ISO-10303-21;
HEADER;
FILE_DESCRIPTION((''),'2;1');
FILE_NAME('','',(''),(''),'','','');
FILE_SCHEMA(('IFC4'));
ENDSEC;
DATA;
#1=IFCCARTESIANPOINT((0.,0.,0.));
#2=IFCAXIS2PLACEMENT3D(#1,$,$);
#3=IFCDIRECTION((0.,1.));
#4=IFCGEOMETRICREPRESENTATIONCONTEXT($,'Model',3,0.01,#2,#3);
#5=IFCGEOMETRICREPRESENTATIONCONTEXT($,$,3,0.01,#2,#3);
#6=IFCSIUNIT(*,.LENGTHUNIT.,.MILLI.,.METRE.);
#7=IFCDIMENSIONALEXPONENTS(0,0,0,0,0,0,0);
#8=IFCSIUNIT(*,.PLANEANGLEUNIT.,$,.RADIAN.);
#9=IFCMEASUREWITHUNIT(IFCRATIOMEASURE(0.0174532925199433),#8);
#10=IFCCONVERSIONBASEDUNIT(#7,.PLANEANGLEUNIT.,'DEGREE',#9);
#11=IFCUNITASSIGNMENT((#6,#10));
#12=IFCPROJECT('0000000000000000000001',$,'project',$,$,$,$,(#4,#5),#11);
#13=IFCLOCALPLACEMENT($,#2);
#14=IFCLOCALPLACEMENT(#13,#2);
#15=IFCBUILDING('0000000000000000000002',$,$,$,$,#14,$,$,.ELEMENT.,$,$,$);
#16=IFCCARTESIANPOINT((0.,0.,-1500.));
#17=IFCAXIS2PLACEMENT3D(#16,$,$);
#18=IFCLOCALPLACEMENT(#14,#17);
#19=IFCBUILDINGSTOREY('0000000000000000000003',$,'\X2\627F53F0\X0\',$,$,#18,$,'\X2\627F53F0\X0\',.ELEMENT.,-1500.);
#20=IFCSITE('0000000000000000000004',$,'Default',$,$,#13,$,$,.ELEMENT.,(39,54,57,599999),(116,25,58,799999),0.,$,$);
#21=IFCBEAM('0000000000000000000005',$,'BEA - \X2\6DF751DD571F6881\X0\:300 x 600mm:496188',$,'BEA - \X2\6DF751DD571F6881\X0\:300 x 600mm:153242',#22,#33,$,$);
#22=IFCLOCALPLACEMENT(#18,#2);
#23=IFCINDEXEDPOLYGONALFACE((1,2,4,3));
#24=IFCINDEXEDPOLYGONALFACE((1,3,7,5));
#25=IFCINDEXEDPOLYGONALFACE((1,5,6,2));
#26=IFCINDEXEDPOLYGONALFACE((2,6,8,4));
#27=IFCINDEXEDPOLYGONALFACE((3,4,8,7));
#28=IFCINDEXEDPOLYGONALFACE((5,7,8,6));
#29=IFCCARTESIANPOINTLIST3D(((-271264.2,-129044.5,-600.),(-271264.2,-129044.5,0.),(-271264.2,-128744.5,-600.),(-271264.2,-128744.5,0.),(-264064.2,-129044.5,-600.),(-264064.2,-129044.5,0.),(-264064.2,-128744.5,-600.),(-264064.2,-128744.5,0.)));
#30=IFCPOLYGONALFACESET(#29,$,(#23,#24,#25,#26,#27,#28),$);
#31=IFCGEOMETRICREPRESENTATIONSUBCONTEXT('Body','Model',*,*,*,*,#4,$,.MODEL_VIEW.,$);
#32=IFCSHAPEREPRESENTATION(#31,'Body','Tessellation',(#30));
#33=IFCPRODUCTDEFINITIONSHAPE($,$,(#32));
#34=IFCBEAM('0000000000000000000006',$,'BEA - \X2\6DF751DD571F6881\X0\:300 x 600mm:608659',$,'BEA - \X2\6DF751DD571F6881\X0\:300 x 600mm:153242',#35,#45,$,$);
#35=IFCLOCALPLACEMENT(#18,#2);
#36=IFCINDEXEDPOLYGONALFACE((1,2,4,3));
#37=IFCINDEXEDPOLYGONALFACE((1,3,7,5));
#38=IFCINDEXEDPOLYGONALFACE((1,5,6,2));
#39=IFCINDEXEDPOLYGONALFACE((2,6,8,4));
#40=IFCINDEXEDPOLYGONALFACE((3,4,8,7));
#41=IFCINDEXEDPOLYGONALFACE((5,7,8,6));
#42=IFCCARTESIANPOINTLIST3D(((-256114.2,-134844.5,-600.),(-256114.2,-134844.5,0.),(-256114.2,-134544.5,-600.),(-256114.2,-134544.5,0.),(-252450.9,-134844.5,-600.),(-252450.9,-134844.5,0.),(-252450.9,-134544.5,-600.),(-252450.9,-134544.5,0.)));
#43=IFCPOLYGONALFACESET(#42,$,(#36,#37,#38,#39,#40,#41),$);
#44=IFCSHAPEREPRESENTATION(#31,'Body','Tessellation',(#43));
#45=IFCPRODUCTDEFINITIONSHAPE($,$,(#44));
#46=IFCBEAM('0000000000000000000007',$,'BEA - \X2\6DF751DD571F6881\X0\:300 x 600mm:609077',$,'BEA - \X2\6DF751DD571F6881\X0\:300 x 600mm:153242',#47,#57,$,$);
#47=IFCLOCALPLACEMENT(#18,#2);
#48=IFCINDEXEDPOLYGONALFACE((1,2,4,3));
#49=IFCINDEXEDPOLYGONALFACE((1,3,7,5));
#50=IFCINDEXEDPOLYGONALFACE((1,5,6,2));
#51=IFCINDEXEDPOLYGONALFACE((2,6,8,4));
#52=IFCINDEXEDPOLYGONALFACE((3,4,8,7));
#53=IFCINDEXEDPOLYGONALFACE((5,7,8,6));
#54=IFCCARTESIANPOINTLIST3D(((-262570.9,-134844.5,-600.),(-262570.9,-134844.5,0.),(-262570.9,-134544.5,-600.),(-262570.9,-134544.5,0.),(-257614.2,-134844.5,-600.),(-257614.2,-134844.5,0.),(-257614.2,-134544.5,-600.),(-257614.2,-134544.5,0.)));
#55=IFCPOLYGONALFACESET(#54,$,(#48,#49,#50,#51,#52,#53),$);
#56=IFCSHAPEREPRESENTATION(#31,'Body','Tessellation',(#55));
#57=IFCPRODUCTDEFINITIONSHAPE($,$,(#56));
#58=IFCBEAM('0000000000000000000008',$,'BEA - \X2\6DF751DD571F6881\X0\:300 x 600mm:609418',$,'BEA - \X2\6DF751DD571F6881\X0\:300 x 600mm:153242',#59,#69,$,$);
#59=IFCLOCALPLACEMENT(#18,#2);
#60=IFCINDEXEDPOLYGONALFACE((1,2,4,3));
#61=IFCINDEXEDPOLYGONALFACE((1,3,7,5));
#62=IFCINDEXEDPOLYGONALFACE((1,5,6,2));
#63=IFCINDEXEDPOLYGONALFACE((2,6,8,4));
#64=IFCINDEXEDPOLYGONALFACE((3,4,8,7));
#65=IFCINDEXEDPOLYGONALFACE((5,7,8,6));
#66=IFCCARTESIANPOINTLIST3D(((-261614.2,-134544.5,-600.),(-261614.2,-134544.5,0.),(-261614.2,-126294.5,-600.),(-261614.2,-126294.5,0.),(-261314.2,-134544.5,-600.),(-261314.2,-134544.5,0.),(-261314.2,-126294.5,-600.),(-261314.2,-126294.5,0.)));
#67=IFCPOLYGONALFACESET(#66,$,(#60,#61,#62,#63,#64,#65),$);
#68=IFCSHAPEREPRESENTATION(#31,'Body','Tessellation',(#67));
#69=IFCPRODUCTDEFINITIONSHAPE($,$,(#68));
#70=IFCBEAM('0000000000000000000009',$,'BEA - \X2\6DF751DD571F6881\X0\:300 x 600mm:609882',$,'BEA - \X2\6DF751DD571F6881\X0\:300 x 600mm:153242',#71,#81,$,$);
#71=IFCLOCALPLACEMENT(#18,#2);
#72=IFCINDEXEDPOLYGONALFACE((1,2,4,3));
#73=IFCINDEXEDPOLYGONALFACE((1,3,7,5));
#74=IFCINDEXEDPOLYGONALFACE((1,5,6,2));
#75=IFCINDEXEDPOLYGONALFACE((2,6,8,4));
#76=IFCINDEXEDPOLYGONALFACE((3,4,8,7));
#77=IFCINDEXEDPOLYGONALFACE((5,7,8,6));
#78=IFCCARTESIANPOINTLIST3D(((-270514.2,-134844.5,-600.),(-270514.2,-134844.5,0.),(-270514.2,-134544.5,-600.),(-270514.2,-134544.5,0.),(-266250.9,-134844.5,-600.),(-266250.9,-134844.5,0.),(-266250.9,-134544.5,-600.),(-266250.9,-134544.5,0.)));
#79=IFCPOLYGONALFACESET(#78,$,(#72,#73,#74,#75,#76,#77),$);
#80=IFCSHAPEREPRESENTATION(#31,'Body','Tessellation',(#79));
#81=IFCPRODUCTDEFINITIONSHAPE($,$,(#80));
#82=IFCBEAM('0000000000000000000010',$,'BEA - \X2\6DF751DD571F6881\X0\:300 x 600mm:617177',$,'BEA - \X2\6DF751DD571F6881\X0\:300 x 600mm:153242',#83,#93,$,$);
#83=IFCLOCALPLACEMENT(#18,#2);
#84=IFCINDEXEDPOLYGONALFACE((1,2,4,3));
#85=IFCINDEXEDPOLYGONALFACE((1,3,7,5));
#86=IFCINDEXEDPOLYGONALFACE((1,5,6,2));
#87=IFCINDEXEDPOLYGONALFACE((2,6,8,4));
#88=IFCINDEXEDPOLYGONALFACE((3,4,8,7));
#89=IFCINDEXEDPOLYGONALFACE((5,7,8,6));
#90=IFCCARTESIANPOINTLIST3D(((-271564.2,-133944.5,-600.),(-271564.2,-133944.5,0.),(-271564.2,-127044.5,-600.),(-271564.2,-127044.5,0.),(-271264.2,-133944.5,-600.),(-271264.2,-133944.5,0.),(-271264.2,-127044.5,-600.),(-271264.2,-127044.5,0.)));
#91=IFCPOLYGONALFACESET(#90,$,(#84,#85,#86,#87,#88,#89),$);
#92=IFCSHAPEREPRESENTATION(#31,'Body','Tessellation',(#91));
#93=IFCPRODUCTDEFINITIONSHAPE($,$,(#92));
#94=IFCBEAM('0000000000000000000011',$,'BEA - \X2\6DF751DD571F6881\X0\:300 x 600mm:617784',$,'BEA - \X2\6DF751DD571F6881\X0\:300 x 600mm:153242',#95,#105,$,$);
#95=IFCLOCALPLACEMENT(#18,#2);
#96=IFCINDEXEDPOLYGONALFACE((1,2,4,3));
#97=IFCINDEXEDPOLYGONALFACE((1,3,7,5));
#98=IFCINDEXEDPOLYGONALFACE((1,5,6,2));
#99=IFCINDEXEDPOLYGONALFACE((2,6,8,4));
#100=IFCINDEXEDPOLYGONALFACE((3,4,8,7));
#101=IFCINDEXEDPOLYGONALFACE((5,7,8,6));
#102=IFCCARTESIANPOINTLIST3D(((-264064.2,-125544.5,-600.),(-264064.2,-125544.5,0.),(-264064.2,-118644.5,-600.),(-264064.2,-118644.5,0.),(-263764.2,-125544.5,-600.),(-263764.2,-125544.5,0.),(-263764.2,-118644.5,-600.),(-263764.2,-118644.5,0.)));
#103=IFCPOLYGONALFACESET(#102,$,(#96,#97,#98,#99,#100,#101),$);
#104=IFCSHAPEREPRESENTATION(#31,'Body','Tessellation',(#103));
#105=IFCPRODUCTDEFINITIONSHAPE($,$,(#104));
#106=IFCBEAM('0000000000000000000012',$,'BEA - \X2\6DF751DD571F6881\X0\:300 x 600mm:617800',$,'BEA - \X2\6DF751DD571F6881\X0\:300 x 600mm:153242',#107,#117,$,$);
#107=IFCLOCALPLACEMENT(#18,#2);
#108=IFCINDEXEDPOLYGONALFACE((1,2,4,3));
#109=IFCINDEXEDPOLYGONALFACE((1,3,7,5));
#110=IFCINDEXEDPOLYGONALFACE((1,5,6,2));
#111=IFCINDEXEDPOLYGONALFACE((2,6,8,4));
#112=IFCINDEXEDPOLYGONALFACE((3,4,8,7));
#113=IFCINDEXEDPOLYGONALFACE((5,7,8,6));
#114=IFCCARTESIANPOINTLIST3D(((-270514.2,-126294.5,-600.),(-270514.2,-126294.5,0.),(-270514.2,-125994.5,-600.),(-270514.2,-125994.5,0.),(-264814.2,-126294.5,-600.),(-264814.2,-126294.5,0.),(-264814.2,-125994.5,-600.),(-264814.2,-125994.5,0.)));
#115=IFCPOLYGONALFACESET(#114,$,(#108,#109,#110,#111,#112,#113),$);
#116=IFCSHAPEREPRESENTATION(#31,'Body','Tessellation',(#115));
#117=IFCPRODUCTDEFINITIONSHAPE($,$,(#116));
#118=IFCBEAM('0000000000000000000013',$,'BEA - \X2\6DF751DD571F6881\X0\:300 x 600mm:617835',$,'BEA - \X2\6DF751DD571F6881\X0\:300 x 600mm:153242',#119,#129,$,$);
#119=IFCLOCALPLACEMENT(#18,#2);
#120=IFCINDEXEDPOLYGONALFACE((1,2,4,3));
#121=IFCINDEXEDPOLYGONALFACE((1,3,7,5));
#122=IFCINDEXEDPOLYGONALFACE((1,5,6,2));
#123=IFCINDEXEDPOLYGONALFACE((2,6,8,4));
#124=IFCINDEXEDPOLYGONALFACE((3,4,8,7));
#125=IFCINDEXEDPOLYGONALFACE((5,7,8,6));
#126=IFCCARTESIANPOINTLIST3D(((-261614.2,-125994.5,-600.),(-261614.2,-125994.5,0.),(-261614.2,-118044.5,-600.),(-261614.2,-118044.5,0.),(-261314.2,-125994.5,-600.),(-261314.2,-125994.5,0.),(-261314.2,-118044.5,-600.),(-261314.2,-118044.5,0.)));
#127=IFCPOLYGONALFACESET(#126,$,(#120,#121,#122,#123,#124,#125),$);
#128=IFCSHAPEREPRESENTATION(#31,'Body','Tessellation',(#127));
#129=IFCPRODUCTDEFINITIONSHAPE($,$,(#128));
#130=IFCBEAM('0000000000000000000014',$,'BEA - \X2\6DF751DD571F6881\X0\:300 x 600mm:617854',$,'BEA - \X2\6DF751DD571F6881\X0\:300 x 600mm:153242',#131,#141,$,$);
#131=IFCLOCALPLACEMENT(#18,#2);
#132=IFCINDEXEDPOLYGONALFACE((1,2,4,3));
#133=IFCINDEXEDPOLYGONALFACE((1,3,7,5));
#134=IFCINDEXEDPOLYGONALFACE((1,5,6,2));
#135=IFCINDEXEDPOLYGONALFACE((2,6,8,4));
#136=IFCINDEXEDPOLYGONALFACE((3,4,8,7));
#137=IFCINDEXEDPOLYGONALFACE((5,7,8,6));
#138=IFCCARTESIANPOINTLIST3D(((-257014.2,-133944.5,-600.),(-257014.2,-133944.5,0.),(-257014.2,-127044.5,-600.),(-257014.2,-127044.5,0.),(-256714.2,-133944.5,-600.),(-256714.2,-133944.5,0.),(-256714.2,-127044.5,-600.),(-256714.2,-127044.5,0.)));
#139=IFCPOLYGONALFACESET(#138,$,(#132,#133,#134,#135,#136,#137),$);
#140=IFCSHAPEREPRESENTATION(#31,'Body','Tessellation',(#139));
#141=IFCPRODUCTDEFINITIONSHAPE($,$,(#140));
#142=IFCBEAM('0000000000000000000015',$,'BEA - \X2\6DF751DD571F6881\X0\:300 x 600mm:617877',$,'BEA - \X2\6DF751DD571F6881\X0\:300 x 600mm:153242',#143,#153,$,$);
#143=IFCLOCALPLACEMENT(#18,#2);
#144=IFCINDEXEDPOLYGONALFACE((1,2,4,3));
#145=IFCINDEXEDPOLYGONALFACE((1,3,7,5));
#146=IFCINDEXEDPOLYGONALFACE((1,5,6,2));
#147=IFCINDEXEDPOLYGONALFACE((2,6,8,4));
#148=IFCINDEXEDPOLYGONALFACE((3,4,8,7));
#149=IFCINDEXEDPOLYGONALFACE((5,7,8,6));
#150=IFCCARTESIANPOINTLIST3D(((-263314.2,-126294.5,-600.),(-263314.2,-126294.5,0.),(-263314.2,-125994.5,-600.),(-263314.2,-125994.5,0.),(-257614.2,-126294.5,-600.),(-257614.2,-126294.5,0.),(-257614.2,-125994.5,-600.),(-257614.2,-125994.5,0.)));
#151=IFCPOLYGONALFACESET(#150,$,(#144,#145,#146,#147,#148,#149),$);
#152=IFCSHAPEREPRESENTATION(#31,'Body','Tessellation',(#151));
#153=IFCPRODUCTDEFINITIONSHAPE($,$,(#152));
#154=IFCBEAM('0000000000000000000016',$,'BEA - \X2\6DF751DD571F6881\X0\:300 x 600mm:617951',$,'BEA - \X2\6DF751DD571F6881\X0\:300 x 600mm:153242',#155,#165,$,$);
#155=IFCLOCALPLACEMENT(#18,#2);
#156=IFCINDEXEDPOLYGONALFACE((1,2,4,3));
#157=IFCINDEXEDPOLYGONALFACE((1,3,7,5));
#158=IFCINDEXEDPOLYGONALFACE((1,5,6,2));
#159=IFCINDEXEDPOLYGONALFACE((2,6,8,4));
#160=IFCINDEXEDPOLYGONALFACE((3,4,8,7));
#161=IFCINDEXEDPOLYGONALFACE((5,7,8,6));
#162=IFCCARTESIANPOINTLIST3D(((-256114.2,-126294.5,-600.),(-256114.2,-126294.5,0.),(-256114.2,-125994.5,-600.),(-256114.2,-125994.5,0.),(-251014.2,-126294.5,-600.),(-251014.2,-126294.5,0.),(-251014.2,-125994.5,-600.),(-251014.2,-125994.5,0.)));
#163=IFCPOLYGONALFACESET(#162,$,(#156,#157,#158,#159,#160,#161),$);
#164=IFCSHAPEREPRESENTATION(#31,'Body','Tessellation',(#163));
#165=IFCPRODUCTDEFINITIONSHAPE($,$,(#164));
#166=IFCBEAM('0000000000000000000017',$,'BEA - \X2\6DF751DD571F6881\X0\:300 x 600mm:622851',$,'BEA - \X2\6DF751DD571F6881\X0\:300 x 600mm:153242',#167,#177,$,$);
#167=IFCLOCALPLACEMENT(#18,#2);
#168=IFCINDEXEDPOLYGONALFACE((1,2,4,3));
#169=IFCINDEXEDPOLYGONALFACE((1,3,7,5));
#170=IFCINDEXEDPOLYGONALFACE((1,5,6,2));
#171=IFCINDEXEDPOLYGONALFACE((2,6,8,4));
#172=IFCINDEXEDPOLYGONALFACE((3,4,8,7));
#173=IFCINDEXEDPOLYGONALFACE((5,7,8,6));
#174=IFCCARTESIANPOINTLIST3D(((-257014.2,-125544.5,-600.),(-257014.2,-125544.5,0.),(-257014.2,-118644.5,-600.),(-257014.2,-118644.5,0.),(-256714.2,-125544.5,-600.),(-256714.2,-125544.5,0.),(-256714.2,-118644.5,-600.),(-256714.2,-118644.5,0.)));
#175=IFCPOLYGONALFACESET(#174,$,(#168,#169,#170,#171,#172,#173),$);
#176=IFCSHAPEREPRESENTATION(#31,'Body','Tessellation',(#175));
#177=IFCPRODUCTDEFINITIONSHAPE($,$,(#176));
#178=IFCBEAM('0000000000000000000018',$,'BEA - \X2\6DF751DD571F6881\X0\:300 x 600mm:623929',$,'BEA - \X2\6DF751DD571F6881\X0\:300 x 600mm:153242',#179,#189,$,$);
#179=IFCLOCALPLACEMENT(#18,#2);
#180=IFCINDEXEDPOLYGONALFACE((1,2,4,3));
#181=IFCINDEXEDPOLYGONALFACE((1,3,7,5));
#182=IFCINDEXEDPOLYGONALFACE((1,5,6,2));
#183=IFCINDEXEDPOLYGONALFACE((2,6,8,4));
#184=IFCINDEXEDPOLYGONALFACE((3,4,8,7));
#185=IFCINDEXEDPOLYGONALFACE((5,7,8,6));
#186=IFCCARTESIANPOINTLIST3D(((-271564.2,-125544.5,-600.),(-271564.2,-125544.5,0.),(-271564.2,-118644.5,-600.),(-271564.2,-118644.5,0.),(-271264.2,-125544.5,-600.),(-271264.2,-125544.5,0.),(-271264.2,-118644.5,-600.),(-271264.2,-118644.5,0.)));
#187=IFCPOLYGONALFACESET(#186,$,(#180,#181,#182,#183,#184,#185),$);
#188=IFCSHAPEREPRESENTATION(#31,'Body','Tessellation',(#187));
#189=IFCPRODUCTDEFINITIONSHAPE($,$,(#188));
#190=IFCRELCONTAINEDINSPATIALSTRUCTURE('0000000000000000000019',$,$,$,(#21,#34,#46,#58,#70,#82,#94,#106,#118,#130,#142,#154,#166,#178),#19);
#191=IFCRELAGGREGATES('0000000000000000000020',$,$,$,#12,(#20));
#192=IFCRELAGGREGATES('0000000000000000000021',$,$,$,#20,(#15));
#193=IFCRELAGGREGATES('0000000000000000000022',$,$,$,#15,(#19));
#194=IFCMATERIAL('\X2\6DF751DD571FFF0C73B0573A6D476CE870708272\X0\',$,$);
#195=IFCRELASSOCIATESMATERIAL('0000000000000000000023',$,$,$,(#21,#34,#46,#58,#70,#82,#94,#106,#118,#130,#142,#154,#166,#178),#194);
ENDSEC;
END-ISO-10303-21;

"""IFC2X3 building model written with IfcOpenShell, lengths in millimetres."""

from ifc_helpers import new_model, entity, si_unit, converted_unit, direction, frame, frame_2d, origin, origin_2d_with_axis, place, context, subcontext, project, spatial, rectangle, extrude, material, element, save


model = new_model("IFC2X3")

# Units and contexts
model_context = context("Model", 3, precision=0.01, world=origin(), true_north=direction((0.0, 1.0)))
context_of_model = context(None, 3, precision=0.01, world=origin(), true_north=direction((0.0, 1.0)))
body_context = subcontext(model_context, "Body", "Model", "MODEL_VIEW")
ifc_project = project(units=[si_unit("LENGTHUNIT", "METRE", prefix="MILLI"), converted_unit("PLANEANGLEUNIT", "DEGREE", entity("IfcRatioMeasure", 0.0174532925199433), si_unit("PLANEANGLEUNIT", "RADIAN"), dimensions=[0, 0, 0, 0, 0, 0, 0])], contexts=[model_context, context_of_model])

# Site, building, storey
site_placement = place(None, origin())
site = spatial("IfcSite", under=ifc_project, at=site_placement, Name="Default", CompositionType="ELEMENT", RefLatitude=(39, 54, 57, 599999), RefLongitude=(116, 25, 58, 799999), RefElevation=0.0)
building_placement = place(site_placement, origin())
building = spatial("IfcBuilding", under=site, at=building_placement, CompositionType="ELEMENT")
storey_placement = place(building_placement, frame((0.0, 0.0, -1500.0)))
storey = spatial("IfcBuildingStorey", under=building, at=storey_placement, Name="承台", LongName="承台", CompositionType="ELEMENT", Elevation=-1500.0)

# Shared definitions
ifc_material_1 = material(Name="混凝土，现场浇注灰色")

# Beams
beam_1_placement = place(storey_placement, frame((-264064.2, -128894.5, 0.0), z_axis=(0.0, 0.0, 1.0), x_axis=(-1.0, 0.0, 0.0)))
element("IfcBeam", 1, at=beam_1_placement, inside=storey, material=ifc_material_1, Name="BEA - 混凝土梁:300 x 600mm:496188", ObjectType="BEA - 混凝土梁:300 x 600mm:153242", context=body_context, shape_type="SweptSolid", body=[
    extrude(rectangle(XDim=600.0, YDim=300.0, at=frame_2d((0.0, 0.0), x_axis=(1.0, 0.0))), frame((0.0, 0.0, -300.0), z_axis=(1.0, 0.0, 0.0), x_axis=(0.0, 0.0, -1.0)), (0.0, 0.0, 1.0), 7200.0),
])
beam_2_placement = place(storey_placement, frame((-252450.9, -134694.5, 0.0), z_axis=(0.0, 0.0, 1.0), x_axis=(-1.0, 0.0, 0.0)))
element("IfcBeam", 2, at=beam_2_placement, inside=storey, material=ifc_material_1, Name="BEA - 混凝土梁:300 x 600mm:608659", ObjectType="BEA - 混凝土梁:300 x 600mm:153242", context=body_context, shape_type="SweptSolid", body=[
    extrude(rectangle(XDim=600.0, YDim=300.0, at=frame_2d((0.0, 0.0), x_axis=(1.0, 0.0))), frame((0.0, 0.0, -300.0), z_axis=(1.0, 0.0, 0.0), x_axis=(0.0, 0.0, -1.0)), (0.0, 0.0, 1.0), 3663.3),
])
beam_3_placement = place(storey_placement, frame((-257614.2, -134694.5, 0.0), z_axis=(0.0, 0.0, 1.0), x_axis=(-1.0, 0.0, 0.0)))
element("IfcBeam", 3, at=beam_3_placement, inside=storey, material=ifc_material_1, Name="BEA - 混凝土梁:300 x 600mm:609077", ObjectType="BEA - 混凝土梁:300 x 600mm:153242", context=body_context, shape_type="SweptSolid", body=[
    extrude(rectangle(XDim=600.0, YDim=300.0, at=frame_2d((0.0, 0.0), x_axis=(1.0, 0.0))), frame((0.0, 0.0, -300.0), z_axis=(1.0, 0.0, 0.0), x_axis=(0.0, 0.0, -1.0)), (0.0, 0.0, 1.0), 4956.7),
])
beam_4_placement = place(storey_placement, frame((-261464.2, -134544.5, 0.0), z_axis=(0.0, 0.0, 1.0), x_axis=(0.0, 1.0, 0.0)))
element("IfcBeam", 4, at=beam_4_placement, inside=storey, material=ifc_material_1, Name="BEA - 混凝土梁:300 x 600mm:609418", ObjectType="BEA - 混凝土梁:300 x 600mm:153242", context=body_context, shape_type="SweptSolid", body=[
    extrude(rectangle(XDim=600.0, YDim=300.0, at=origin_2d_with_axis()), frame((0.0, 0.0, -300.0), z_axis=(1.0, 0.0, 0.0), x_axis=(0.0, 0.0, -1.0)), (0.0, 0.0, 1.0), 8250.0),
])
beam_5_placement = place(storey_placement, frame((-266250.9, -134694.5, 0.0), z_axis=(0.0, 0.0, 1.0), x_axis=(-1.0, 0.0, 0.0)))
element("IfcBeam", 5, at=beam_5_placement, inside=storey, material=ifc_material_1, Name="BEA - 混凝土梁:300 x 600mm:609882", ObjectType="BEA - 混凝土梁:300 x 600mm:153242", context=body_context, shape_type="SweptSolid", body=[
    extrude(rectangle(XDim=600.0, YDim=300.0, at=frame_2d((0.0, 0.0), x_axis=(1.0, 0.0))), frame((0.0, 0.0, -300.0), z_axis=(1.0, 0.0, 0.0), x_axis=(0.0, 0.0, -1.0)), (0.0, 0.0, 1.0), 4263.3),
])
for number, where, z_axis, x_axis, name in (
    (6, (-271414.2, -127044.5, 0.0), (0.0, 0.0, 1.0), (0.0, -1.0, 0.0), "BEA - 混凝土梁:300 x 600mm:617177"),
    (7, (-263914.2, -125544.5, 0.0), (0.0, 0.0, 1.0), (0.0, 1.0, 0.0), "BEA - 混凝土梁:300 x 600mm:617784"),
):
    element("IfcBeam", number, at=place(storey_placement, frame(where, z_axis=z_axis, x_axis=x_axis)), inside=storey, material=ifc_material_1, Name=name, ObjectType="BEA - 混凝土梁:300 x 600mm:153242", context=body_context, shape_type="SweptSolid", body=[
        extrude(rectangle(XDim=600.0, YDim=300.0, at=origin_2d_with_axis()), frame((0.0, 0.0, -300.0), z_axis=(1.0, 0.0, 0.0), x_axis=(0.0, 0.0, -1.0)), (0.0, 0.0, 1.0), 6900.0),
    ])
beam_6_placement = place(storey_placement, frame((-264814.2, -126144.5, 0.0), z_axis=(0.0, 0.0, 1.0), x_axis=(-1.0, 0.0, 0.0)))
element("IfcBeam", 8, at=beam_6_placement, inside=storey, material=ifc_material_1, Name="BEA - 混凝土梁:300 x 600mm:617800", ObjectType="BEA - 混凝土梁:300 x 600mm:153242", context=body_context, shape_type="SweptSolid", body=[
    extrude(rectangle(XDim=600.0, YDim=300.0, at=frame_2d((0.0, 0.0), x_axis=(1.0, 0.0))), frame((0.0, 0.0, -300.0), z_axis=(1.0, 0.0, 0.0), x_axis=(0.0, 0.0, -1.0)), (0.0, 0.0, 1.0), 5700.0),
])
beam_7_placement = place(storey_placement, frame((-261464.2, -125994.5, 0.0), z_axis=(0.0, 0.0, 1.0), x_axis=(0.0, 1.0, 0.0)))
element("IfcBeam", 9, at=beam_7_placement, inside=storey, material=ifc_material_1, Name="BEA - 混凝土梁:300 x 600mm:617835", ObjectType="BEA - 混凝土梁:300 x 600mm:153242", context=body_context, shape_type="SweptSolid", body=[
    extrude(rectangle(XDim=600.0, YDim=300.0, at=origin_2d_with_axis()), frame((0.0, 0.0, -300.0), z_axis=(1.0, 0.0, 0.0), x_axis=(0.0, 0.0, -1.0)), (0.0, 0.0, 1.0), 7950.0),
])
beam_8_placement = place(storey_placement, frame((-256864.2, -127044.5, 0.0), z_axis=(0.0, 0.0, 1.0), x_axis=(0.0, -1.0, 0.0)))
element("IfcBeam", 10, at=beam_8_placement, inside=storey, material=ifc_material_1, Name="BEA - 混凝土梁:300 x 600mm:617854", ObjectType="BEA - 混凝土梁:300 x 600mm:153242", context=body_context, shape_type="SweptSolid", body=[
    extrude(rectangle(XDim=600.0, YDim=300.0, at=origin_2d_with_axis()), frame((0.0, 0.0, -300.0), z_axis=(1.0, 0.0, 0.0), x_axis=(0.0, 0.0, -1.0)), (0.0, 0.0, 1.0), 6900.0),
])
beam_9_placement = place(storey_placement, frame((-257614.2, -126144.5, 0.0), z_axis=(0.0, 0.0, 1.0), x_axis=(-1.0, 0.0, 0.0)))
element("IfcBeam", 11, at=beam_9_placement, inside=storey, material=ifc_material_1, Name="BEA - 混凝土梁:300 x 600mm:617877", ObjectType="BEA - 混凝土梁:300 x 600mm:153242", context=body_context, shape_type="SweptSolid", body=[
    extrude(rectangle(XDim=600.0, YDim=300.0, at=frame_2d((0.0, 0.0), x_axis=(1.0, 0.0))), frame((0.0, 0.0, -300.0), z_axis=(1.0, 0.0, 0.0), x_axis=(0.0, 0.0, -1.0)), (0.0, 0.0, 1.0), 5700.0),
])
beam_10_placement = place(storey_placement, frame((-251014.2, -126144.5, 0.0), z_axis=(0.0, 0.0, 1.0), x_axis=(-1.0, 0.0, 0.0)))
element("IfcBeam", 12, at=beam_10_placement, inside=storey, material=ifc_material_1, Name="BEA - 混凝土梁:300 x 600mm:617951", ObjectType="BEA - 混凝土梁:300 x 600mm:153242", context=body_context, shape_type="SweptSolid", body=[
    extrude(rectangle(XDim=600.0, YDim=300.0, at=frame_2d((0.0, 0.0), x_axis=(1.0, 0.0))), frame((0.0, 0.0, -300.0), z_axis=(1.0, 0.0, 0.0), x_axis=(0.0, 0.0, -1.0)), (0.0, 0.0, 1.0), 5100.0),
])
for number, where, z_axis, x_axis, name in (
    (13, (-256864.2, -118644.5, 0.0), (0.0, 0.0, 1.0), (0.0, -1.0, 0.0), "BEA - 混凝土梁:300 x 600mm:622851"),
    (14, (-271414.2, -118644.5, 0.0), (0.0, 0.0, 1.0), (0.0, -1.0, 0.0), "BEA - 混凝土梁:300 x 600mm:623929"),
):
    element("IfcBeam", number, at=place(storey_placement, frame(where, z_axis=z_axis, x_axis=x_axis)), inside=storey, material=ifc_material_1, Name=name, ObjectType="BEA - 混凝土梁:300 x 600mm:153242", context=body_context, shape_type="SweptSolid", body=[
        extrude(rectangle(XDim=600.0, YDim=300.0, at=origin_2d_with_axis()), frame((0.0, 0.0, -300.0), z_axis=(1.0, 0.0, 0.0), x_axis=(0.0, 0.0, -1.0)), (0.0, 0.0, 1.0), 6900.0),
    ])

save(model, "model.ifc")
